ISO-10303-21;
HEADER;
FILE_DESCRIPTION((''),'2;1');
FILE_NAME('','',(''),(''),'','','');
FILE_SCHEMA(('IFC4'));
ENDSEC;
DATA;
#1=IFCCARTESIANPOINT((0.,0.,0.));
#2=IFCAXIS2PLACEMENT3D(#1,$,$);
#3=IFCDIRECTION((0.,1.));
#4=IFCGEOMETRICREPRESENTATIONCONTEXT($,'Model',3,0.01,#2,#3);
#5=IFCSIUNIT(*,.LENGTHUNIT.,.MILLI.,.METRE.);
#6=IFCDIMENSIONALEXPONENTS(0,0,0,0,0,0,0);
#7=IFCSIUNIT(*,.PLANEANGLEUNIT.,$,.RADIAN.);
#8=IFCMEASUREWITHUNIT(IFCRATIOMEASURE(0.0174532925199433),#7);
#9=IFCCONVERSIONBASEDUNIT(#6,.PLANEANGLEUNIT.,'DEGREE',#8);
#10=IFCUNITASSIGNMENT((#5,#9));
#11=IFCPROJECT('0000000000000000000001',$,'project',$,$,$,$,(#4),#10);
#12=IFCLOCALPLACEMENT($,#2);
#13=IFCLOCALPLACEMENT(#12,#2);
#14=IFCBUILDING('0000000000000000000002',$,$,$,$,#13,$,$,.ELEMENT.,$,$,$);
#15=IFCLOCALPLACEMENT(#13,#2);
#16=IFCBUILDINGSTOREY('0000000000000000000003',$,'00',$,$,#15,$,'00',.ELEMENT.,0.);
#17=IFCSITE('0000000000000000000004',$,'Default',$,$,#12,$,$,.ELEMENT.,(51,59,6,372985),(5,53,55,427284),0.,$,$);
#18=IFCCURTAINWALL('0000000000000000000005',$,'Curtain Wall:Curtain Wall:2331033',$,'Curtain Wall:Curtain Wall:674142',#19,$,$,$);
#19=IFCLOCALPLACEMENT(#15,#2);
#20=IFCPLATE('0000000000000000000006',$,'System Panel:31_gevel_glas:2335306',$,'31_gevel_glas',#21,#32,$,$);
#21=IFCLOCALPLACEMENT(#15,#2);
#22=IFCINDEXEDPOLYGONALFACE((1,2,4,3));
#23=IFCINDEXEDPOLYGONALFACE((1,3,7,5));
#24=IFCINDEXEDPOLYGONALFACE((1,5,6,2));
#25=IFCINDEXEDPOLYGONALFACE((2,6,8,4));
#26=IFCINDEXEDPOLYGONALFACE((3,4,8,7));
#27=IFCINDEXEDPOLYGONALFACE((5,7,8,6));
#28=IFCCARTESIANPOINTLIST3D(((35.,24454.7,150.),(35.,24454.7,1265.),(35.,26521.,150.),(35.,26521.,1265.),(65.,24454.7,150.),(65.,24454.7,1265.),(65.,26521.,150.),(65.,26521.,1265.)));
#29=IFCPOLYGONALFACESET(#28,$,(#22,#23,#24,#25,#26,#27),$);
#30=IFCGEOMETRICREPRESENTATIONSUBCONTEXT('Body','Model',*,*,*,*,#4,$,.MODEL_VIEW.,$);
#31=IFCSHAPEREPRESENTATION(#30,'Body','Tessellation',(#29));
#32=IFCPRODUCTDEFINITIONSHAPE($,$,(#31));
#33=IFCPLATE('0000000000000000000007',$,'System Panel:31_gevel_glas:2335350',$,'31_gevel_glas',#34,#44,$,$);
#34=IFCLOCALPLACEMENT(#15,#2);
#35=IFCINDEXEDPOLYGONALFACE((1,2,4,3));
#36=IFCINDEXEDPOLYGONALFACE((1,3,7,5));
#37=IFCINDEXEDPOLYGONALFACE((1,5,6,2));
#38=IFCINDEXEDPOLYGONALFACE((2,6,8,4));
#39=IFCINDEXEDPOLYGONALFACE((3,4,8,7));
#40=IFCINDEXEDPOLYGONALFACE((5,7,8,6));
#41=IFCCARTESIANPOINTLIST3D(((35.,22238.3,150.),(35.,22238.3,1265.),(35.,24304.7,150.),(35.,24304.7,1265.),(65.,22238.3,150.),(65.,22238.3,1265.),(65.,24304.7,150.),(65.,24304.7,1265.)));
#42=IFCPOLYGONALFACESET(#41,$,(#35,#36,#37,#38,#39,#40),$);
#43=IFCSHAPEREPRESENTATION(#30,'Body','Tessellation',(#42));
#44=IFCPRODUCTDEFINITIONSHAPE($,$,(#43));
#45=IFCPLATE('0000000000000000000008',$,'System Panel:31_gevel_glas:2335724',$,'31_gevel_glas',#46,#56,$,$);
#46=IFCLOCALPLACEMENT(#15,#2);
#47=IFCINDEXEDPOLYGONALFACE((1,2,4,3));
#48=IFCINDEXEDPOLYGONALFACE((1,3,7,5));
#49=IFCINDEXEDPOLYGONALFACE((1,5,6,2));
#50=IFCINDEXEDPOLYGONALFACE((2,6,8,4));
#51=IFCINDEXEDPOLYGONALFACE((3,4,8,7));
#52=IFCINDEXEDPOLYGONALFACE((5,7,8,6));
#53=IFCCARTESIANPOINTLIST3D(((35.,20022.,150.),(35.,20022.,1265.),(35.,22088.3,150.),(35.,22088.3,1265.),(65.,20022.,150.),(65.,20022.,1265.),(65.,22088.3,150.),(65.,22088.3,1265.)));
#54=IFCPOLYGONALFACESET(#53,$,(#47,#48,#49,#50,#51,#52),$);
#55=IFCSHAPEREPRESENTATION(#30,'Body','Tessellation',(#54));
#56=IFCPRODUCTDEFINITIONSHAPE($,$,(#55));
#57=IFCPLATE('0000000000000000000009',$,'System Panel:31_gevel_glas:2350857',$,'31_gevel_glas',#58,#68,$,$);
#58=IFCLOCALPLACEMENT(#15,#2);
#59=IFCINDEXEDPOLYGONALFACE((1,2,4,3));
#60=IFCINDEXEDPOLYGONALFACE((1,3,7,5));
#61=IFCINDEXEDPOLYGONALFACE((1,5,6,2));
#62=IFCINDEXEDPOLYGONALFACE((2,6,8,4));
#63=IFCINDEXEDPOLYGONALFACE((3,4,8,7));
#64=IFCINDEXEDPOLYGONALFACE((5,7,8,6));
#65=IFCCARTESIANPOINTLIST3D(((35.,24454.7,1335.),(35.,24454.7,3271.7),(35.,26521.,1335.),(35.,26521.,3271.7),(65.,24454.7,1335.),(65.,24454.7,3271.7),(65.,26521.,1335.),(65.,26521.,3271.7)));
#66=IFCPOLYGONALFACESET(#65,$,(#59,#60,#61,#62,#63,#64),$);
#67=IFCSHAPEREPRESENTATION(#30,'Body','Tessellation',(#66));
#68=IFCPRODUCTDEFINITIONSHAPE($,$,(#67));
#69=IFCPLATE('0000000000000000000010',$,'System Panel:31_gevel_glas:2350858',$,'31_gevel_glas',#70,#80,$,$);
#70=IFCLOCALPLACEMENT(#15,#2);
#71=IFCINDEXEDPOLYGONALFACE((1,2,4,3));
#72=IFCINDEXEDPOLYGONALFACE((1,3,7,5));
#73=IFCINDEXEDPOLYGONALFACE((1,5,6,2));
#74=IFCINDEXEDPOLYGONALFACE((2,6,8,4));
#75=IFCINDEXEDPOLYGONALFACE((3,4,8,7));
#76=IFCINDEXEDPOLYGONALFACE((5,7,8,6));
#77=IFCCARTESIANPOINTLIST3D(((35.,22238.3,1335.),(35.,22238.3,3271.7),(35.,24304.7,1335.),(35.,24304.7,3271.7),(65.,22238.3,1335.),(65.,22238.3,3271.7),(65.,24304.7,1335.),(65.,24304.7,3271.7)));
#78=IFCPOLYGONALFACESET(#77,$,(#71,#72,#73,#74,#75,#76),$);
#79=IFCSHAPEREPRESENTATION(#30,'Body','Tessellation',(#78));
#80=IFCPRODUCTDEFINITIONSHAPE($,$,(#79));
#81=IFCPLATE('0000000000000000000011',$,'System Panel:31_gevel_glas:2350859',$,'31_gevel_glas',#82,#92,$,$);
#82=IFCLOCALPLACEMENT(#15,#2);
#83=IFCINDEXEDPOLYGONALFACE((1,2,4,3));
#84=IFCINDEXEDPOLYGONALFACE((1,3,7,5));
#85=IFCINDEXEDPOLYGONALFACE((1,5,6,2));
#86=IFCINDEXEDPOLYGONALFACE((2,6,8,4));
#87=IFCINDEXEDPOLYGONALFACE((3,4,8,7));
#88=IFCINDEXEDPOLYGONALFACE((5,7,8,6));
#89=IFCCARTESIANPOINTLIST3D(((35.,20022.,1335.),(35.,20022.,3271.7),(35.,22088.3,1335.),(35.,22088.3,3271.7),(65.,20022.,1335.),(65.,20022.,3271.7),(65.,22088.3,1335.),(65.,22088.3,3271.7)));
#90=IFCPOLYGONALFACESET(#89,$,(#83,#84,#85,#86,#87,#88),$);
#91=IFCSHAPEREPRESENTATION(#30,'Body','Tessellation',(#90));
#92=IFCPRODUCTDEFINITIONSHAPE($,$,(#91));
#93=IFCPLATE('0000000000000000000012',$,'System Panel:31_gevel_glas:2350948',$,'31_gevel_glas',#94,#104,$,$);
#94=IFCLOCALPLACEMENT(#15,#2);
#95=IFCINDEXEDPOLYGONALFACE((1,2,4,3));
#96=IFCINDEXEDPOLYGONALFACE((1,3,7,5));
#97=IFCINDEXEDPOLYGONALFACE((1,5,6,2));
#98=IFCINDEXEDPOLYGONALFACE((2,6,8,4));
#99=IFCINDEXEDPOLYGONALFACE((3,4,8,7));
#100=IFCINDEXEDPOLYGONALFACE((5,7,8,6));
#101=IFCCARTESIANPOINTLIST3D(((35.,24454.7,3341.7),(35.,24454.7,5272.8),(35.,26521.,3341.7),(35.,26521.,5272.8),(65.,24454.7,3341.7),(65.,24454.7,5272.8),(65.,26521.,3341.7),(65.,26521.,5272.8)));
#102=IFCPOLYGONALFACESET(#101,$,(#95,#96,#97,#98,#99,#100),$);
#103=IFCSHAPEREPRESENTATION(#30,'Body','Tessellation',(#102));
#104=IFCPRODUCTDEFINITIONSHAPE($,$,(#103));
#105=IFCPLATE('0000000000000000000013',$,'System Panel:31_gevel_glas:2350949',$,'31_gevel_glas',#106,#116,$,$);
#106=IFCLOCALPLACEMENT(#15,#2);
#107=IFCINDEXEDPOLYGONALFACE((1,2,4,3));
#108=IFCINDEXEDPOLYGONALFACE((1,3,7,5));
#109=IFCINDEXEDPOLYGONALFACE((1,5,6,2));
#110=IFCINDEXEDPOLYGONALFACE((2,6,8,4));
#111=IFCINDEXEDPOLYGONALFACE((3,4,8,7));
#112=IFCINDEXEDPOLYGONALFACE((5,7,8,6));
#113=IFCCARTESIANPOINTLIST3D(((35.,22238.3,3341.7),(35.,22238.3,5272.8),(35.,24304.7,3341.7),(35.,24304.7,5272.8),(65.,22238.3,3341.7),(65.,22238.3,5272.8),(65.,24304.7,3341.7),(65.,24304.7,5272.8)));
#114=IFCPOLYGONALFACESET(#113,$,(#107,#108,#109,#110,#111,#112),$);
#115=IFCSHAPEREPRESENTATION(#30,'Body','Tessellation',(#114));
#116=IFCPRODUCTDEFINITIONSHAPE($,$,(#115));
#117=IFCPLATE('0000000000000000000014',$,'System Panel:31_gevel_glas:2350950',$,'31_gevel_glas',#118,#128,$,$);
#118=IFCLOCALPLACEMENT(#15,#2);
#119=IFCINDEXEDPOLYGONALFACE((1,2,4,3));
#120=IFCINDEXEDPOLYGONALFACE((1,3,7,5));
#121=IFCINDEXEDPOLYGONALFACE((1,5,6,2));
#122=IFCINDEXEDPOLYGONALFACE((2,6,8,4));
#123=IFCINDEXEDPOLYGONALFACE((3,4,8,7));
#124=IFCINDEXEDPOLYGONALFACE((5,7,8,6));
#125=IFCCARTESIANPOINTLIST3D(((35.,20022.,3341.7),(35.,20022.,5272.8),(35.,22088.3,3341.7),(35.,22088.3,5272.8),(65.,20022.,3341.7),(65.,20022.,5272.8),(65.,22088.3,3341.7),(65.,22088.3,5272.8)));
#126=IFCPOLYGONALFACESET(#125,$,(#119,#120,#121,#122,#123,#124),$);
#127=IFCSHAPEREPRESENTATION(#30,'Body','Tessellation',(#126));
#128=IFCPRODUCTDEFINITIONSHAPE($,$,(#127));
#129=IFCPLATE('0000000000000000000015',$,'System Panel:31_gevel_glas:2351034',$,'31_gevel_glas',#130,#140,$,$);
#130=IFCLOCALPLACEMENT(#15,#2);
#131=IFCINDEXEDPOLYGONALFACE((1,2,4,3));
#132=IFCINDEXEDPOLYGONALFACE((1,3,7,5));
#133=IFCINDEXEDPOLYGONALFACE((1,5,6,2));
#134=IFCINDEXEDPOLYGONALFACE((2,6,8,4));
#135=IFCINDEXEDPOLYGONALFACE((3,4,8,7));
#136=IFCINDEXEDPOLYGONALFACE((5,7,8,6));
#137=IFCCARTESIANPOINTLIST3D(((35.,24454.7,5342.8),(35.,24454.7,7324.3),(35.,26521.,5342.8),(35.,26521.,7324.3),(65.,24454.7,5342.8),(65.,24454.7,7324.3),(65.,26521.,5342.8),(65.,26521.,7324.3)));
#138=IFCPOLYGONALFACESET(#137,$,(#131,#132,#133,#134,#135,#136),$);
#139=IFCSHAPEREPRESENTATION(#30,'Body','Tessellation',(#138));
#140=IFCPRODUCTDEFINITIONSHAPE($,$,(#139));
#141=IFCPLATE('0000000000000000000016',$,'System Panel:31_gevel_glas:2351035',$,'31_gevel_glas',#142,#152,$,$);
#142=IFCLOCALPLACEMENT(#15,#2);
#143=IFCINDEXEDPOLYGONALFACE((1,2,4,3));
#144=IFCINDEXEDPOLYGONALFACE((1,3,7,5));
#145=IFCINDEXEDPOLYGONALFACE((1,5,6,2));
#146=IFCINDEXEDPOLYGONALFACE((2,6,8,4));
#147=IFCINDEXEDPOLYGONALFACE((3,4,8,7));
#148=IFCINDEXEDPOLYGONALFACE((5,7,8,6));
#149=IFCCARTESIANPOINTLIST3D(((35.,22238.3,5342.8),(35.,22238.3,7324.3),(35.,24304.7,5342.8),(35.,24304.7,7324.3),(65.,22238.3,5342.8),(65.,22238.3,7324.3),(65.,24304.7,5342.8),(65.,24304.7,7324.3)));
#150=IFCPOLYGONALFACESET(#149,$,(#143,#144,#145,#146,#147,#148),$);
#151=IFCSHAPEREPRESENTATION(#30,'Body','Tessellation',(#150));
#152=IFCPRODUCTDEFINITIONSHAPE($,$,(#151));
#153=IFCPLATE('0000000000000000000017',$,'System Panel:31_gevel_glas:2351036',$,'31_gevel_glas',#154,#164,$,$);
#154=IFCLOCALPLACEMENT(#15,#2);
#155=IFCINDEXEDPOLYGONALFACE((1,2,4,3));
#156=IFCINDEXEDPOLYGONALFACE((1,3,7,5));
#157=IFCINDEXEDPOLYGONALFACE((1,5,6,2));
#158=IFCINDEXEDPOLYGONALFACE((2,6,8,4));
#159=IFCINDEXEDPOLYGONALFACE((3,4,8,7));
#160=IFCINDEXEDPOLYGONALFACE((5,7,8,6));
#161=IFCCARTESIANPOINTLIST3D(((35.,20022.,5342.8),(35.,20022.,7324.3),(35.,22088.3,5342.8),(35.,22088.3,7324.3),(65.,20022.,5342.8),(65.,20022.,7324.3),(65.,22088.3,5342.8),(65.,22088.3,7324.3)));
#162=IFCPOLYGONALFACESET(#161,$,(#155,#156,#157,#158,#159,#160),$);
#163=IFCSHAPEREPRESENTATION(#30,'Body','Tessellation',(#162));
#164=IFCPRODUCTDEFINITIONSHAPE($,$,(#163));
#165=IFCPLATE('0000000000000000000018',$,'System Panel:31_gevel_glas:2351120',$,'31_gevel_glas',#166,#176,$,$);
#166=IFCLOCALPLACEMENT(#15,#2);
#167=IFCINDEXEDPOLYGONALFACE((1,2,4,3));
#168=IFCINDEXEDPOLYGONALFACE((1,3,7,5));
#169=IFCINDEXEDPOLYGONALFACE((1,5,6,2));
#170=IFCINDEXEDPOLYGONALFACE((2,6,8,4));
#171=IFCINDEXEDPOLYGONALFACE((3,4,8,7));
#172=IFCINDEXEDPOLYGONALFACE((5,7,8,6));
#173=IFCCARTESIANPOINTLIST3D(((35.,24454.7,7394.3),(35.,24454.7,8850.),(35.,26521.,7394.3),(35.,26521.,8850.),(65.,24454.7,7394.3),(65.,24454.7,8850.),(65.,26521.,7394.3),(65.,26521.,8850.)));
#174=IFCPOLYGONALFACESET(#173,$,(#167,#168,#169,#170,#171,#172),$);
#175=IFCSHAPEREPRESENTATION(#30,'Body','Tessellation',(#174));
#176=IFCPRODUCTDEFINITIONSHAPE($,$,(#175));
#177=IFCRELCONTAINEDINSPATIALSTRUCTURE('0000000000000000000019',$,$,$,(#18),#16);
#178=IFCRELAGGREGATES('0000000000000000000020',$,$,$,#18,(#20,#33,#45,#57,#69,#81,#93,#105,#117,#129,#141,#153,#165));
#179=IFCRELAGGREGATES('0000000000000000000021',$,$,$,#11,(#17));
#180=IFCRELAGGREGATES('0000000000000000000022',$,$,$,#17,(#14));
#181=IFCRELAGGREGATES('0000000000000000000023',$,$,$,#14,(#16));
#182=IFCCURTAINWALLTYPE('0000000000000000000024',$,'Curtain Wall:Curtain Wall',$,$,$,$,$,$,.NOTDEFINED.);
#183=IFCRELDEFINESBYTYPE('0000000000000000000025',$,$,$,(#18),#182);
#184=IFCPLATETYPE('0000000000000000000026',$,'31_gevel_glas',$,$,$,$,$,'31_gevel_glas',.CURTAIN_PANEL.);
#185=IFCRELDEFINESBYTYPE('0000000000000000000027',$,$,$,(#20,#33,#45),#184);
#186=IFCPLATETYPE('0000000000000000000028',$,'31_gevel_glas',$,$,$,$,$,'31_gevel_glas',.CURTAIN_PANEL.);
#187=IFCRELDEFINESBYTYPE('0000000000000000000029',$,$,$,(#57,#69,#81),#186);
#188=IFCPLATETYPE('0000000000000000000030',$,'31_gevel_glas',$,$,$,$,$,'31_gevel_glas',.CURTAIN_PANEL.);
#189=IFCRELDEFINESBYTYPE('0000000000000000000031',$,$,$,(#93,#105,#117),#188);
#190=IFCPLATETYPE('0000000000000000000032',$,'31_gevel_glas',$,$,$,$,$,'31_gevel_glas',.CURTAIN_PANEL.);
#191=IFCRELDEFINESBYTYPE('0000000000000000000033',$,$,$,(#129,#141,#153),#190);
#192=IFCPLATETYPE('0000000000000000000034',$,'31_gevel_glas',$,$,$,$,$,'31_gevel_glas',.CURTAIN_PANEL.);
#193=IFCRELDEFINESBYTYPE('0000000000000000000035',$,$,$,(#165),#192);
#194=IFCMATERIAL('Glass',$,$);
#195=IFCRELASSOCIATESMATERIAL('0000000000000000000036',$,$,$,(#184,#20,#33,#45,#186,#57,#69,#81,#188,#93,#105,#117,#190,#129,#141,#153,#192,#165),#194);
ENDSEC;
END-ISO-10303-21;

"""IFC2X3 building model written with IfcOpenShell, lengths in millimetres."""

from ifc_helpers import new_model, entity, si_unit, converted_unit, direction, frame, origin, origin_2d_with_axis, place, context, subcontext, project, spatial, rectangle, extrude, source, transform, mapped, material, type_object, type_shapes, element, aggregate, save


model = new_model("IFC2X3")

# Units and contexts
model_context = context("Model", 3, precision=0.01, world=origin(), true_north=direction((0.0, 1.0)))
body_context = subcontext(model_context, "Body", "Model", "MODEL_VIEW")
ifc_project = project(units=[si_unit("LENGTHUNIT", "METRE", prefix="MILLI"), converted_unit("PLANEANGLEUNIT", "DEGREE", entity("IfcRatioMeasure", 0.0174532925199433), si_unit("PLANEANGLEUNIT", "RADIAN"), dimensions=[0, 0, 0, 0, 0, 0, 0])], contexts=[model_context])

# Site, building, storey
site_placement = place(None, origin())
site = spatial("IfcSite", under=ifc_project, at=site_placement, Name="Default", CompositionType="ELEMENT", RefLatitude=(51, 59, 6, 372985), RefLongitude=(5, 53, 55, 427284), RefElevation=0.0)
building_placement = place(site_placement, origin())
building = spatial("IfcBuilding", under=site, at=building_placement, CompositionType="ELEMENT")
storey_placement = place(building_placement, origin())
storey = spatial("IfcBuildingStorey", under=building, at=storey_placement, Name="00", LongName="00", CompositionType="ELEMENT", Elevation=0.0)

# Curtain wall, plates
curtain_wall_type = type_object("IfcCurtainWallType", Name="Curtain Wall:Curtain Wall", PredefinedType="NOTDEFINED")
curtain_wall_placement = place(storey_placement, origin())
curtain_wall = element("IfcCurtainWall", 1, at=curtain_wall_placement, inside=storey, type_object=curtain_wall_type, Name="Curtain Wall:Curtain Wall:2331033", ObjectType="Curtain Wall:Curtain Wall:674142")
ifc_material_1 = material(Name="Glass")
plate_type_1 = type_object("IfcPlateType", Name="31_gevel_glas", ElementType="31_gevel_glas", PredefinedType="CURTAIN_PANEL", material=ifc_material_1)
shared_shape_1 = source(origin(), body_context, "Body", "SweptSolid", [
    extrude(rectangle(XDim=30.0, YDim=2066.3, at=origin_2d_with_axis()), frame((0.0, 50.0, 0.0), z_axis=(0.0, 0.0, 1.0), x_axis=(0.0, 1.0, 0.0)), (0.0, 0.0, 1.0), 1115.0),
])
type_shapes(plate_type_1, [shared_shape_1])
plate_1_placement = place(curtain_wall_placement, frame((0.0, 25487.8, 150.0), z_axis=(0.0, 0.0, 1.0), x_axis=(0.0, -1.0, 0.0)))
plate_1 = element("IfcPlate", 2, at=plate_1_placement, type_object=plate_type_1, material=ifc_material_1, Name="System Panel:31_gevel_glas:2335306", ObjectType="31_gevel_glas", context=body_context, shape_type="MappedRepresentation", body=[
    mapped(shared_shape_1, transform((0.0, 0.0, 0.0), scale=1.0)),
])
plate_2_placement = place(curtain_wall_placement, frame((0.0, 23271.5, 150.0), z_axis=(0.0, 0.0, 1.0), x_axis=(0.0, -1.0, 0.0)))
plate_2 = element("IfcPlate", 3, at=plate_2_placement, type_object=plate_type_1, material=ifc_material_1, Name="System Panel:31_gevel_glas:2335350", ObjectType="31_gevel_glas", context=body_context, shape_type="MappedRepresentation", body=[
    mapped(shared_shape_1, transform((0.0, 0.0, 0.0), scale=1.0)),
])
plate_3_placement = place(curtain_wall_placement, frame((0.0, 21055.2, 150.0), z_axis=(0.0, 0.0, 1.0), x_axis=(0.0, -1.0, 0.0)))
plate_3 = element("IfcPlate", 4, at=plate_3_placement, type_object=plate_type_1, material=ifc_material_1, Name="System Panel:31_gevel_glas:2335724", ObjectType="31_gevel_glas", context=body_context, shape_type="MappedRepresentation", body=[
    mapped(shared_shape_1, transform((0.0, 0.0, 0.0), scale=1.0)),
])
plate_type_2 = type_object("IfcPlateType", Name="31_gevel_glas", ElementType="31_gevel_glas", PredefinedType="CURTAIN_PANEL", material=ifc_material_1)
shared_shape_2 = source(origin(), body_context, "Body", "SweptSolid", [
    extrude(rectangle(XDim=30.0, YDim=2066.3, at=origin_2d_with_axis()), frame((0.0, 50.0, 0.0), z_axis=(0.0, 0.0, 1.0), x_axis=(0.0, 1.0, 0.0)), (0.0, 0.0, 1.0), 1936.7),
])
type_shapes(plate_type_2, [shared_shape_2])
plate_4_placement = place(curtain_wall_placement, frame((0.0, 25487.8, 1335.0), z_axis=(0.0, 0.0, 1.0), x_axis=(0.0, -1.0, 0.0)))
plate_4 = element("IfcPlate", 5, at=plate_4_placement, type_object=plate_type_2, material=ifc_material_1, Name="System Panel:31_gevel_glas:2350857", ObjectType="31_gevel_glas", context=body_context, shape_type="MappedRepresentation", body=[
    mapped(shared_shape_2, transform((0.0, 0.0, 0.0), scale=1.0)),
])
plate_5_placement = place(curtain_wall_placement, frame((0.0, 23271.5, 1335.0), z_axis=(0.0, 0.0, 1.0), x_axis=(0.0, -1.0, 0.0)))
plate_5 = element("IfcPlate", 6, at=plate_5_placement, type_object=plate_type_2, material=ifc_material_1, Name="System Panel:31_gevel_glas:2350858", ObjectType="31_gevel_glas", context=body_context, shape_type="MappedRepresentation", body=[
    mapped(shared_shape_2, transform((0.0, 0.0, 0.0), scale=1.0)),
])
plate_6_placement = place(curtain_wall_placement, frame((0.0, 21055.2, 1335.0), z_axis=(0.0, 0.0, 1.0), x_axis=(0.0, -1.0, 0.0)))
plate_6 = element("IfcPlate", 7, at=plate_6_placement, type_object=plate_type_2, material=ifc_material_1, Name="System Panel:31_gevel_glas:2350859", ObjectType="31_gevel_glas", context=body_context, shape_type="MappedRepresentation", body=[
    mapped(shared_shape_2, transform((0.0, 0.0, 0.0), scale=1.0)),
])
plate_type_3 = type_object("IfcPlateType", Name="31_gevel_glas", ElementType="31_gevel_glas", PredefinedType="CURTAIN_PANEL", material=ifc_material_1)
shared_shape_3 = source(origin(), body_context, "Body", "SweptSolid", [
    extrude(rectangle(XDim=30.0, YDim=2066.3, at=origin_2d_with_axis()), frame((0.0, 50.0, 0.0), z_axis=(0.0, 0.0, 1.0), x_axis=(0.0, 1.0, 0.0)), (0.0, 0.0, 1.0), 1931.1),
])
type_shapes(plate_type_3, [shared_shape_3])
plate_7_placement = place(curtain_wall_placement, frame((0.0, 25487.8, 3341.7), z_axis=(0.0, 0.0, 1.0), x_axis=(0.0, -1.0, 0.0)))
plate_7 = element("IfcPlate", 8, at=plate_7_placement, type_object=plate_type_3, material=ifc_material_1, Name="System Panel:31_gevel_glas:2350948", ObjectType="31_gevel_glas", context=body_context, shape_type="MappedRepresentation", body=[
    mapped(shared_shape_3, transform((0.0, 0.0, 0.0), scale=1.0)),
])
plate_8_placement = place(curtain_wall_placement, frame((0.0, 23271.5, 3341.7), z_axis=(0.0, 0.0, 1.0), x_axis=(0.0, -1.0, 0.0)))
plate_8 = element("IfcPlate", 9, at=plate_8_placement, type_object=plate_type_3, material=ifc_material_1, Name="System Panel:31_gevel_glas:2350949", ObjectType="31_gevel_glas", context=body_context, shape_type="MappedRepresentation", body=[
    mapped(shared_shape_3, transform((0.0, 0.0, 0.0), scale=1.0)),
])
plate_9_placement = place(curtain_wall_placement, frame((0.0, 21055.2, 3341.7), z_axis=(0.0, 0.0, 1.0), x_axis=(0.0, -1.0, 0.0)))
plate_9 = element("IfcPlate", 10, at=plate_9_placement, type_object=plate_type_3, material=ifc_material_1, Name="System Panel:31_gevel_glas:2350950", ObjectType="31_gevel_glas", context=body_context, shape_type="MappedRepresentation", body=[
    mapped(shared_shape_3, transform((0.0, 0.0, 0.0), scale=1.0)),
])
plate_type_4 = type_object("IfcPlateType", Name="31_gevel_glas", ElementType="31_gevel_glas", PredefinedType="CURTAIN_PANEL", material=ifc_material_1)
shared_shape_4 = source(origin(), body_context, "Body", "SweptSolid", [
    extrude(rectangle(XDim=30.0, YDim=2066.3, at=origin_2d_with_axis()), frame((0.0, 50.0, 0.0), z_axis=(0.0, 0.0, 1.0), x_axis=(0.0, 1.0, 0.0)), (0.0, 0.0, 1.0), 1981.5),
])
type_shapes(plate_type_4, [shared_shape_4])
plate_10_placement = place(curtain_wall_placement, frame((0.0, 25487.8, 5342.8), z_axis=(0.0, 0.0, 1.0), x_axis=(0.0, -1.0, 0.0)))
plate_10 = element("IfcPlate", 11, at=plate_10_placement, type_object=plate_type_4, material=ifc_material_1, Name="System Panel:31_gevel_glas:2351034", ObjectType="31_gevel_glas", context=body_context, shape_type="MappedRepresentation", body=[
    mapped(shared_shape_4, transform((0.0, 0.0, 0.0), scale=1.0)),
])
plate_11_placement = place(curtain_wall_placement, frame((0.0, 23271.5, 5342.8), z_axis=(0.0, 0.0, 1.0), x_axis=(0.0, -1.0, 0.0)))
plate_11 = element("IfcPlate", 12, at=plate_11_placement, type_object=plate_type_4, material=ifc_material_1, Name="System Panel:31_gevel_glas:2351035", ObjectType="31_gevel_glas", context=body_context, shape_type="MappedRepresentation", body=[
    mapped(shared_shape_4, transform((0.0, 0.0, 0.0), scale=1.0)),
])
plate_12_placement = place(curtain_wall_placement, frame((0.0, 21055.2, 5342.8), z_axis=(0.0, 0.0, 1.0), x_axis=(0.0, -1.0, 0.0)))
plate_12 = element("IfcPlate", 13, at=plate_12_placement, type_object=plate_type_4, material=ifc_material_1, Name="System Panel:31_gevel_glas:2351036", ObjectType="31_gevel_glas", context=body_context, shape_type="MappedRepresentation", body=[
    mapped(shared_shape_4, transform((0.0, 0.0, 0.0), scale=1.0)),
])
plate_type_5 = type_object("IfcPlateType", Name="31_gevel_glas", ElementType="31_gevel_glas", PredefinedType="CURTAIN_PANEL", material=ifc_material_1)
shared_shape_5 = source(origin(), body_context, "Body", "SweptSolid", [
    extrude(rectangle(XDim=30.0, YDim=2066.3, at=origin_2d_with_axis()), frame((0.0, 50.0, 0.0), z_axis=(0.0, 0.0, 1.0), x_axis=(0.0, 1.0, 0.0)), (0.0, 0.0, 1.0), 1455.7),
])
type_shapes(plate_type_5, [shared_shape_5])
plate_13_placement = place(curtain_wall_placement, frame((0.0, 25487.8, 7394.3), z_axis=(0.0, 0.0, 1.0), x_axis=(0.0, -1.0, 0.0)))
plate_13 = element("IfcPlate", 14, at=plate_13_placement, type_object=plate_type_5, material=ifc_material_1, Name="System Panel:31_gevel_glas:2351120", ObjectType="31_gevel_glas", context=body_context, shape_type="MappedRepresentation", body=[
    mapped(shared_shape_5, transform((0.0, 0.0, 0.0), scale=1.0)),
])
aggregate(curtain_wall, [plate_1, plate_2, plate_3, plate_4, plate_5, plate_6, plate_7, plate_8, plate_9, plate_10, plate_11, plate_12, plate_13])

save(model, "model.ifc")
